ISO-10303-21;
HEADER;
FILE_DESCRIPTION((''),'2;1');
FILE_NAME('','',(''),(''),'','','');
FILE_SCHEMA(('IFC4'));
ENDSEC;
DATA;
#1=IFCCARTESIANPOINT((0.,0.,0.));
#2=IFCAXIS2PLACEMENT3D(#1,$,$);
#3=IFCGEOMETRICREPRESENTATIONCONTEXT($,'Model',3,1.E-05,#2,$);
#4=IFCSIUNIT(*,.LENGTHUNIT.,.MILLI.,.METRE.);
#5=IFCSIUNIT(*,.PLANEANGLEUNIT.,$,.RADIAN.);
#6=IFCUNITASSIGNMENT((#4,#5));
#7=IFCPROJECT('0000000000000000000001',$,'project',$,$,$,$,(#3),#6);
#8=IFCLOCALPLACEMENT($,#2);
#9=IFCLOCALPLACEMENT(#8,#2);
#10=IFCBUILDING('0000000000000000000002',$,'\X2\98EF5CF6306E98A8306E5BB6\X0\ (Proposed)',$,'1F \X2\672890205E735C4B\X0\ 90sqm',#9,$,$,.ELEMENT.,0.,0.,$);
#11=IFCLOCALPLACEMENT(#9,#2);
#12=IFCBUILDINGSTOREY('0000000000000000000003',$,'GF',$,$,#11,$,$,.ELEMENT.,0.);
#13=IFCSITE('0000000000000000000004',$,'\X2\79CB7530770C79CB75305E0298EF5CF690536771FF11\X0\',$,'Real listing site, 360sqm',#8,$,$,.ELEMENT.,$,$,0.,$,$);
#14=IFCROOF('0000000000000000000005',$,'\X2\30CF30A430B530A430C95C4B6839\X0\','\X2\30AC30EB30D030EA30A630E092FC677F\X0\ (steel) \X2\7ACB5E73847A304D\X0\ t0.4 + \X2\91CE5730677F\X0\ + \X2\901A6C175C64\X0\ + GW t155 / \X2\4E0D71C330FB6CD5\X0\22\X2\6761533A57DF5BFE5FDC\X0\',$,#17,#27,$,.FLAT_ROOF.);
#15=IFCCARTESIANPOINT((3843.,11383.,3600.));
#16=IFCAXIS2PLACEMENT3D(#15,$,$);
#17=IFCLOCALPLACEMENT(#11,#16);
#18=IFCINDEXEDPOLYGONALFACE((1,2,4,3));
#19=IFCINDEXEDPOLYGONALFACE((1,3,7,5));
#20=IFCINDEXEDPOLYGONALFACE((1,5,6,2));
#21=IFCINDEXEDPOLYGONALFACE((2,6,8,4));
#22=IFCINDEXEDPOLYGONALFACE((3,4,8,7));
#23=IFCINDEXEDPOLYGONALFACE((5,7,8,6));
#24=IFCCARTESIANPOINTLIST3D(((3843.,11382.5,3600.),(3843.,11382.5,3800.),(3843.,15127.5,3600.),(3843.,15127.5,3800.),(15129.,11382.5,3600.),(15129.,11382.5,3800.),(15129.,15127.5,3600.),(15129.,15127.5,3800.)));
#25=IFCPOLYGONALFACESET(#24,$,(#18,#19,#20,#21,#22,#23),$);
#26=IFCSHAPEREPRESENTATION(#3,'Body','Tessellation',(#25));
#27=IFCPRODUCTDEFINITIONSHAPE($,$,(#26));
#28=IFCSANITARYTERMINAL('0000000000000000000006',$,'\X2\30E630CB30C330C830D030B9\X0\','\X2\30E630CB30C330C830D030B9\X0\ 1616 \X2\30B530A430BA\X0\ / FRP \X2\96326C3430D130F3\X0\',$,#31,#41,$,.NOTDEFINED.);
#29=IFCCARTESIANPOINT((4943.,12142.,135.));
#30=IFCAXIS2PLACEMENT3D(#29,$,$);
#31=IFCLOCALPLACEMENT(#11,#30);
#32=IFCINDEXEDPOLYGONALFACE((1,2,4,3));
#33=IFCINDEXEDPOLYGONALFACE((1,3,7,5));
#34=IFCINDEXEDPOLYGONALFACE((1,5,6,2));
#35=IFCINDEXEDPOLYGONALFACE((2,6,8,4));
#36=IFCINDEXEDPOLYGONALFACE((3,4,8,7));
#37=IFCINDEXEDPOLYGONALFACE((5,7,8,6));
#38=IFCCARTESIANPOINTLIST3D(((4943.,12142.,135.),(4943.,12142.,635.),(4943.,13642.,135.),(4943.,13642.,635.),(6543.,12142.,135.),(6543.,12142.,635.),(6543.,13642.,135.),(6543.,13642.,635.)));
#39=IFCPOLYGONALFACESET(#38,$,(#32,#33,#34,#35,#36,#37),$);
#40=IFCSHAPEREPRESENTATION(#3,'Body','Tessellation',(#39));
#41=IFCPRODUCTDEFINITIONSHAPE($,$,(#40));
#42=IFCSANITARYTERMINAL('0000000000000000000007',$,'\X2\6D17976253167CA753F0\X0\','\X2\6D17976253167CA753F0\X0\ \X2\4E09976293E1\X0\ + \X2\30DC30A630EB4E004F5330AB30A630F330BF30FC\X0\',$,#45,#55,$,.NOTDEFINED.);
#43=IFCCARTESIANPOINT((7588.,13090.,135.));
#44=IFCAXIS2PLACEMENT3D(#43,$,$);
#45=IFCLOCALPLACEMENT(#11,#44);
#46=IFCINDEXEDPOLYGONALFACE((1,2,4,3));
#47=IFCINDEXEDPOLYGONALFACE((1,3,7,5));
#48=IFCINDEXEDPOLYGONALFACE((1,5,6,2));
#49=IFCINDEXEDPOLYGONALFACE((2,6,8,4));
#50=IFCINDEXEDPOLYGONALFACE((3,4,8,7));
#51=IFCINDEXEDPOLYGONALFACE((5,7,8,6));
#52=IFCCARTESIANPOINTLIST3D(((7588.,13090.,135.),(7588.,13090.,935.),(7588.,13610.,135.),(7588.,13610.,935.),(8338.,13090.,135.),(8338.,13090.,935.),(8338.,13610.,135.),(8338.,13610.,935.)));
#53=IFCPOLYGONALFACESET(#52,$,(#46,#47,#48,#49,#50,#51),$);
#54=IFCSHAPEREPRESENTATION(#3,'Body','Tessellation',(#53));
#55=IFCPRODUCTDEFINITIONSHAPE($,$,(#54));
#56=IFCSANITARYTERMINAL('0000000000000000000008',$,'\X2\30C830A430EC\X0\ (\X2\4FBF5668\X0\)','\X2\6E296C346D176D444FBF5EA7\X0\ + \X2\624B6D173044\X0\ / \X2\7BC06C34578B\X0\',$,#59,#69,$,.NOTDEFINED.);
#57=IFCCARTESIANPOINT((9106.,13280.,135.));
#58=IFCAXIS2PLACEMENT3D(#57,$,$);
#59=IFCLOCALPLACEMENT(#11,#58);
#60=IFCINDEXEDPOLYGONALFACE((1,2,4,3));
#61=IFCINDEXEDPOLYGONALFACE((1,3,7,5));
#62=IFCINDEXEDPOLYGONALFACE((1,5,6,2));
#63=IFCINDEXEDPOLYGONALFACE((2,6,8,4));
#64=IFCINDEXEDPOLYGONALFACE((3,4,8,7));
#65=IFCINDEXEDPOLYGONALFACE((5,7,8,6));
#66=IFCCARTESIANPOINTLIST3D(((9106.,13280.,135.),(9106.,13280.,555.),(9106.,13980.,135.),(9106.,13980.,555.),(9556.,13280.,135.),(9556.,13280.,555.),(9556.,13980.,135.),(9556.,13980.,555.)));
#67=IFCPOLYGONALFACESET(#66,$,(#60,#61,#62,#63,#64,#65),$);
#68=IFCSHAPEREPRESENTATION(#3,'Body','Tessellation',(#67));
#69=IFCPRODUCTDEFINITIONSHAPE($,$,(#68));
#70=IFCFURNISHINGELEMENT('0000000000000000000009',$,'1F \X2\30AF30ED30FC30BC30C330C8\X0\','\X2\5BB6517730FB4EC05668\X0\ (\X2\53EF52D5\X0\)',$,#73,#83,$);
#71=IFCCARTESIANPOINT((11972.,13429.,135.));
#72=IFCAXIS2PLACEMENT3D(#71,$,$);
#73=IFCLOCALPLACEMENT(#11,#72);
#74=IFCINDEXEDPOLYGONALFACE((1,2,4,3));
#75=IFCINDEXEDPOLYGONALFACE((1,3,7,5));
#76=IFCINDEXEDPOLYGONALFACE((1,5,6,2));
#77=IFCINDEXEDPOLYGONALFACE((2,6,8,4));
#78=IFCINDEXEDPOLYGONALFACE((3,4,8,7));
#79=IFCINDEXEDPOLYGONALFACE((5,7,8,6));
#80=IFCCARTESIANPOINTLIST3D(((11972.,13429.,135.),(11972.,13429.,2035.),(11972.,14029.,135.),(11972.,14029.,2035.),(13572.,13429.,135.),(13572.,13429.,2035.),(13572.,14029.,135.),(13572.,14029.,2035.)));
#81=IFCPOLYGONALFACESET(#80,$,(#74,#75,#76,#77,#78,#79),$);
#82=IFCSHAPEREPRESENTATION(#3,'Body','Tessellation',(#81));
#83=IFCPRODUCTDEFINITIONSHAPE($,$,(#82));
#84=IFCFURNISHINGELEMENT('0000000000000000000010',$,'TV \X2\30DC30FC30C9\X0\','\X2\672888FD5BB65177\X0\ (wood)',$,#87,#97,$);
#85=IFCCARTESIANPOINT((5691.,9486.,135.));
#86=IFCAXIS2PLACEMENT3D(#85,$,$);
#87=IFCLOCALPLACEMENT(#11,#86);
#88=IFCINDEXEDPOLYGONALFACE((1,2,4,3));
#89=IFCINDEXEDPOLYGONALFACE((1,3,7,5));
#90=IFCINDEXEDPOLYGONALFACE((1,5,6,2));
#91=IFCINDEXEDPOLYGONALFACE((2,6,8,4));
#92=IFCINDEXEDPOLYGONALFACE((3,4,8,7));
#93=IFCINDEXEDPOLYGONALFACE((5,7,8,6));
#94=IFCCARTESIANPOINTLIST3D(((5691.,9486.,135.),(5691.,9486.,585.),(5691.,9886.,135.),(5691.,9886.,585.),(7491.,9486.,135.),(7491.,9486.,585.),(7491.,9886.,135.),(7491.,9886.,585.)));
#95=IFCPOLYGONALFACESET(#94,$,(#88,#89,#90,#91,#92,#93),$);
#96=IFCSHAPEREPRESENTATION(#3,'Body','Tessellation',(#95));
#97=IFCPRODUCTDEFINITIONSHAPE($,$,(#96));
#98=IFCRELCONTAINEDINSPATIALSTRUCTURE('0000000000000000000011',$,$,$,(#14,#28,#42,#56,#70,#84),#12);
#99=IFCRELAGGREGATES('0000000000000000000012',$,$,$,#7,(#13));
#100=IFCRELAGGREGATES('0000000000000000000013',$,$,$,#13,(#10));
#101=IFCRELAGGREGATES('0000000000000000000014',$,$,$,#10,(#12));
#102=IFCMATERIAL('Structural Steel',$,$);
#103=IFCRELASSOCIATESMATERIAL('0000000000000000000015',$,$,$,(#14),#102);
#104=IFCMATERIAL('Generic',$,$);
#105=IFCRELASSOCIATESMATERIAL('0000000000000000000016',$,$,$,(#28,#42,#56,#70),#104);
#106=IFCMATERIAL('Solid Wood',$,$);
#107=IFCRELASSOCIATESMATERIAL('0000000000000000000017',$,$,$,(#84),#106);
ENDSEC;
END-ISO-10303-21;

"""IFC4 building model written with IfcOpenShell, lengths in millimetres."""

from ifc_helpers import new_model, si_unit, frame, frame_2d, origin, place, context, project, spatial, rectangle, extrude, material, element, save


model = new_model("IFC4")

# Units and contexts
model_context = context("Model", 3, precision=1e-05, world=origin())
ifc_project = project(units=[si_unit("LENGTHUNIT", "METRE", prefix="MILLI"), si_unit("PLANEANGLEUNIT", "RADIAN")], contexts=[model_context])

# Site, building, storey
site_placement = place(None, origin())
site = spatial("IfcSite", under=ifc_project, at=site_placement, Name="秋田県秋田市飯島道東１", ObjectType="Real listing site, 360sqm", CompositionType="ELEMENT", RefElevation=0.0)
building_placement = place(site_placement, origin())
building = spatial("IfcBuilding", under=site, at=building_placement, Name="飯島の風の家 (Proposed)", ObjectType="1F 木造平屋 90sqm", CompositionType="ELEMENT", ElevationOfRefHeight=0.0, ElevationOfTerrain=0.0)
storey_placement = place(building_placement, origin())
storey = spatial("IfcBuildingStorey", under=building, at=storey_placement, Name="GF", CompositionType="ELEMENT", Elevation=0.0)

# Shared definitions
ifc_material_1 = material(Name="Solid Wood")

# Roof
ifc_material_2 = material(Name="Structural Steel")
roof_placement = place(storey_placement, frame((3843.0, 11383.0, 3600.0)))
element("IfcRoof", 1, at=roof_placement, inside=storey, material=ifc_material_2, Name="ハイサイド屋根", Description="ガルバリウム鋼板 (steel) 立平葺き t0.4 + 野地板 + 通気層 + GW t155 / 不燃・法22条区域対応", PredefinedType="FLAT_ROOF", context=model_context, shape_type="SweptSolid", body=[
    extrude(rectangle(XDim=11286.0, YDim=3745.0, at=frame_2d((5643.0, 1872.0))), frame((3843.0, 11383.0, 3600.0)), (0.0, 0.0, 1.0), 200.0),
])

# Sanitary terminals
ifc_material_3 = material(Name="Generic")
sanitary_terminal_1_placement = place(storey_placement, frame((4943.0, 12142.0, 135.0)))
element("IfcSanitaryTerminal", 2, at=sanitary_terminal_1_placement, inside=storey, material=ifc_material_3, Name="ユニットバス", Description="ユニットバス 1616 サイズ / FRP 防水パン", PredefinedType="NOTDEFINED", context=model_context, shape_type="SweptSolid", body=[
    extrude(rectangle(XDim=1600.0, YDim=1500.0, at=frame_2d((800.0, 750.0))), frame((4943.0, 12142.0, 135.0)), (0.0, 0.0, 1.0), 500.0),
])
sanitary_terminal_2_placement = place(storey_placement, frame((7588.0, 13090.0, 135.0)))
element("IfcSanitaryTerminal", 3, at=sanitary_terminal_2_placement, inside=storey, material=ifc_material_3, Name="洗面化粧台", Description="洗面化粧台 三面鏡 + ボウル一体カウンター", PredefinedType="NOTDEFINED", context=model_context, shape_type="SweptSolid", body=[
    extrude(rectangle(XDim=750.0, YDim=520.0, at=frame_2d((375.0, 260.0))), frame((7588.0, 13090.0, 135.0)), (0.0, 0.0, 1.0), 800.0),
])
sanitary_terminal_3_placement = place(storey_placement, frame((9106.0, 13280.0, 135.0)))
element("IfcSanitaryTerminal", 4, at=sanitary_terminal_3_placement, inside=storey, material=ifc_material_3, Name="トイレ (便器)", Description="温水洗浄便座 + 手洗い / 節水型", PredefinedType="NOTDEFINED", context=model_context, shape_type="SweptSolid", body=[
    extrude(rectangle(XDim=450.0, YDim=700.0, at=frame_2d((225.0, 350.0))), frame((9106.0, 13280.0, 135.0)), (0.0, 0.0, 1.0), 420.0),
])

# Furnishing elements
furnishing_1_placement = place(storey_placement, frame((11972.0, 13429.0, 135.0)))
element("IfcFurnishingElement", 5, at=furnishing_1_placement, inside=storey, material=ifc_material_3, Name="1F クローゼット", Description="家具・什器 (可動)", context=model_context, shape_type="SweptSolid", body=[
    extrude(rectangle(XDim=1600.0, YDim=600.0, at=frame_2d((800.0, 300.0))), frame((11972.0, 13429.0, 135.0)), (0.0, 0.0, 1.0), 1900.0),
])
furnishing_2_placement = place(storey_placement, frame((5691.0, 9486.0, 135.0)))
element("IfcFurnishingElement", 6, at=furnishing_2_placement, inside=storey, material=ifc_material_1, Name="TV ボード", Description="木製家具 (wood)", context=model_context, shape_type="SweptSolid", body=[
    extrude(rectangle(XDim=1800.0, YDim=400.0, at=frame_2d((900.0, 200.0))), frame((5691.0, 9486.0, 135.0)), (0.0, 0.0, 1.0), 450.0),
])

save(model, "model.ifc")
